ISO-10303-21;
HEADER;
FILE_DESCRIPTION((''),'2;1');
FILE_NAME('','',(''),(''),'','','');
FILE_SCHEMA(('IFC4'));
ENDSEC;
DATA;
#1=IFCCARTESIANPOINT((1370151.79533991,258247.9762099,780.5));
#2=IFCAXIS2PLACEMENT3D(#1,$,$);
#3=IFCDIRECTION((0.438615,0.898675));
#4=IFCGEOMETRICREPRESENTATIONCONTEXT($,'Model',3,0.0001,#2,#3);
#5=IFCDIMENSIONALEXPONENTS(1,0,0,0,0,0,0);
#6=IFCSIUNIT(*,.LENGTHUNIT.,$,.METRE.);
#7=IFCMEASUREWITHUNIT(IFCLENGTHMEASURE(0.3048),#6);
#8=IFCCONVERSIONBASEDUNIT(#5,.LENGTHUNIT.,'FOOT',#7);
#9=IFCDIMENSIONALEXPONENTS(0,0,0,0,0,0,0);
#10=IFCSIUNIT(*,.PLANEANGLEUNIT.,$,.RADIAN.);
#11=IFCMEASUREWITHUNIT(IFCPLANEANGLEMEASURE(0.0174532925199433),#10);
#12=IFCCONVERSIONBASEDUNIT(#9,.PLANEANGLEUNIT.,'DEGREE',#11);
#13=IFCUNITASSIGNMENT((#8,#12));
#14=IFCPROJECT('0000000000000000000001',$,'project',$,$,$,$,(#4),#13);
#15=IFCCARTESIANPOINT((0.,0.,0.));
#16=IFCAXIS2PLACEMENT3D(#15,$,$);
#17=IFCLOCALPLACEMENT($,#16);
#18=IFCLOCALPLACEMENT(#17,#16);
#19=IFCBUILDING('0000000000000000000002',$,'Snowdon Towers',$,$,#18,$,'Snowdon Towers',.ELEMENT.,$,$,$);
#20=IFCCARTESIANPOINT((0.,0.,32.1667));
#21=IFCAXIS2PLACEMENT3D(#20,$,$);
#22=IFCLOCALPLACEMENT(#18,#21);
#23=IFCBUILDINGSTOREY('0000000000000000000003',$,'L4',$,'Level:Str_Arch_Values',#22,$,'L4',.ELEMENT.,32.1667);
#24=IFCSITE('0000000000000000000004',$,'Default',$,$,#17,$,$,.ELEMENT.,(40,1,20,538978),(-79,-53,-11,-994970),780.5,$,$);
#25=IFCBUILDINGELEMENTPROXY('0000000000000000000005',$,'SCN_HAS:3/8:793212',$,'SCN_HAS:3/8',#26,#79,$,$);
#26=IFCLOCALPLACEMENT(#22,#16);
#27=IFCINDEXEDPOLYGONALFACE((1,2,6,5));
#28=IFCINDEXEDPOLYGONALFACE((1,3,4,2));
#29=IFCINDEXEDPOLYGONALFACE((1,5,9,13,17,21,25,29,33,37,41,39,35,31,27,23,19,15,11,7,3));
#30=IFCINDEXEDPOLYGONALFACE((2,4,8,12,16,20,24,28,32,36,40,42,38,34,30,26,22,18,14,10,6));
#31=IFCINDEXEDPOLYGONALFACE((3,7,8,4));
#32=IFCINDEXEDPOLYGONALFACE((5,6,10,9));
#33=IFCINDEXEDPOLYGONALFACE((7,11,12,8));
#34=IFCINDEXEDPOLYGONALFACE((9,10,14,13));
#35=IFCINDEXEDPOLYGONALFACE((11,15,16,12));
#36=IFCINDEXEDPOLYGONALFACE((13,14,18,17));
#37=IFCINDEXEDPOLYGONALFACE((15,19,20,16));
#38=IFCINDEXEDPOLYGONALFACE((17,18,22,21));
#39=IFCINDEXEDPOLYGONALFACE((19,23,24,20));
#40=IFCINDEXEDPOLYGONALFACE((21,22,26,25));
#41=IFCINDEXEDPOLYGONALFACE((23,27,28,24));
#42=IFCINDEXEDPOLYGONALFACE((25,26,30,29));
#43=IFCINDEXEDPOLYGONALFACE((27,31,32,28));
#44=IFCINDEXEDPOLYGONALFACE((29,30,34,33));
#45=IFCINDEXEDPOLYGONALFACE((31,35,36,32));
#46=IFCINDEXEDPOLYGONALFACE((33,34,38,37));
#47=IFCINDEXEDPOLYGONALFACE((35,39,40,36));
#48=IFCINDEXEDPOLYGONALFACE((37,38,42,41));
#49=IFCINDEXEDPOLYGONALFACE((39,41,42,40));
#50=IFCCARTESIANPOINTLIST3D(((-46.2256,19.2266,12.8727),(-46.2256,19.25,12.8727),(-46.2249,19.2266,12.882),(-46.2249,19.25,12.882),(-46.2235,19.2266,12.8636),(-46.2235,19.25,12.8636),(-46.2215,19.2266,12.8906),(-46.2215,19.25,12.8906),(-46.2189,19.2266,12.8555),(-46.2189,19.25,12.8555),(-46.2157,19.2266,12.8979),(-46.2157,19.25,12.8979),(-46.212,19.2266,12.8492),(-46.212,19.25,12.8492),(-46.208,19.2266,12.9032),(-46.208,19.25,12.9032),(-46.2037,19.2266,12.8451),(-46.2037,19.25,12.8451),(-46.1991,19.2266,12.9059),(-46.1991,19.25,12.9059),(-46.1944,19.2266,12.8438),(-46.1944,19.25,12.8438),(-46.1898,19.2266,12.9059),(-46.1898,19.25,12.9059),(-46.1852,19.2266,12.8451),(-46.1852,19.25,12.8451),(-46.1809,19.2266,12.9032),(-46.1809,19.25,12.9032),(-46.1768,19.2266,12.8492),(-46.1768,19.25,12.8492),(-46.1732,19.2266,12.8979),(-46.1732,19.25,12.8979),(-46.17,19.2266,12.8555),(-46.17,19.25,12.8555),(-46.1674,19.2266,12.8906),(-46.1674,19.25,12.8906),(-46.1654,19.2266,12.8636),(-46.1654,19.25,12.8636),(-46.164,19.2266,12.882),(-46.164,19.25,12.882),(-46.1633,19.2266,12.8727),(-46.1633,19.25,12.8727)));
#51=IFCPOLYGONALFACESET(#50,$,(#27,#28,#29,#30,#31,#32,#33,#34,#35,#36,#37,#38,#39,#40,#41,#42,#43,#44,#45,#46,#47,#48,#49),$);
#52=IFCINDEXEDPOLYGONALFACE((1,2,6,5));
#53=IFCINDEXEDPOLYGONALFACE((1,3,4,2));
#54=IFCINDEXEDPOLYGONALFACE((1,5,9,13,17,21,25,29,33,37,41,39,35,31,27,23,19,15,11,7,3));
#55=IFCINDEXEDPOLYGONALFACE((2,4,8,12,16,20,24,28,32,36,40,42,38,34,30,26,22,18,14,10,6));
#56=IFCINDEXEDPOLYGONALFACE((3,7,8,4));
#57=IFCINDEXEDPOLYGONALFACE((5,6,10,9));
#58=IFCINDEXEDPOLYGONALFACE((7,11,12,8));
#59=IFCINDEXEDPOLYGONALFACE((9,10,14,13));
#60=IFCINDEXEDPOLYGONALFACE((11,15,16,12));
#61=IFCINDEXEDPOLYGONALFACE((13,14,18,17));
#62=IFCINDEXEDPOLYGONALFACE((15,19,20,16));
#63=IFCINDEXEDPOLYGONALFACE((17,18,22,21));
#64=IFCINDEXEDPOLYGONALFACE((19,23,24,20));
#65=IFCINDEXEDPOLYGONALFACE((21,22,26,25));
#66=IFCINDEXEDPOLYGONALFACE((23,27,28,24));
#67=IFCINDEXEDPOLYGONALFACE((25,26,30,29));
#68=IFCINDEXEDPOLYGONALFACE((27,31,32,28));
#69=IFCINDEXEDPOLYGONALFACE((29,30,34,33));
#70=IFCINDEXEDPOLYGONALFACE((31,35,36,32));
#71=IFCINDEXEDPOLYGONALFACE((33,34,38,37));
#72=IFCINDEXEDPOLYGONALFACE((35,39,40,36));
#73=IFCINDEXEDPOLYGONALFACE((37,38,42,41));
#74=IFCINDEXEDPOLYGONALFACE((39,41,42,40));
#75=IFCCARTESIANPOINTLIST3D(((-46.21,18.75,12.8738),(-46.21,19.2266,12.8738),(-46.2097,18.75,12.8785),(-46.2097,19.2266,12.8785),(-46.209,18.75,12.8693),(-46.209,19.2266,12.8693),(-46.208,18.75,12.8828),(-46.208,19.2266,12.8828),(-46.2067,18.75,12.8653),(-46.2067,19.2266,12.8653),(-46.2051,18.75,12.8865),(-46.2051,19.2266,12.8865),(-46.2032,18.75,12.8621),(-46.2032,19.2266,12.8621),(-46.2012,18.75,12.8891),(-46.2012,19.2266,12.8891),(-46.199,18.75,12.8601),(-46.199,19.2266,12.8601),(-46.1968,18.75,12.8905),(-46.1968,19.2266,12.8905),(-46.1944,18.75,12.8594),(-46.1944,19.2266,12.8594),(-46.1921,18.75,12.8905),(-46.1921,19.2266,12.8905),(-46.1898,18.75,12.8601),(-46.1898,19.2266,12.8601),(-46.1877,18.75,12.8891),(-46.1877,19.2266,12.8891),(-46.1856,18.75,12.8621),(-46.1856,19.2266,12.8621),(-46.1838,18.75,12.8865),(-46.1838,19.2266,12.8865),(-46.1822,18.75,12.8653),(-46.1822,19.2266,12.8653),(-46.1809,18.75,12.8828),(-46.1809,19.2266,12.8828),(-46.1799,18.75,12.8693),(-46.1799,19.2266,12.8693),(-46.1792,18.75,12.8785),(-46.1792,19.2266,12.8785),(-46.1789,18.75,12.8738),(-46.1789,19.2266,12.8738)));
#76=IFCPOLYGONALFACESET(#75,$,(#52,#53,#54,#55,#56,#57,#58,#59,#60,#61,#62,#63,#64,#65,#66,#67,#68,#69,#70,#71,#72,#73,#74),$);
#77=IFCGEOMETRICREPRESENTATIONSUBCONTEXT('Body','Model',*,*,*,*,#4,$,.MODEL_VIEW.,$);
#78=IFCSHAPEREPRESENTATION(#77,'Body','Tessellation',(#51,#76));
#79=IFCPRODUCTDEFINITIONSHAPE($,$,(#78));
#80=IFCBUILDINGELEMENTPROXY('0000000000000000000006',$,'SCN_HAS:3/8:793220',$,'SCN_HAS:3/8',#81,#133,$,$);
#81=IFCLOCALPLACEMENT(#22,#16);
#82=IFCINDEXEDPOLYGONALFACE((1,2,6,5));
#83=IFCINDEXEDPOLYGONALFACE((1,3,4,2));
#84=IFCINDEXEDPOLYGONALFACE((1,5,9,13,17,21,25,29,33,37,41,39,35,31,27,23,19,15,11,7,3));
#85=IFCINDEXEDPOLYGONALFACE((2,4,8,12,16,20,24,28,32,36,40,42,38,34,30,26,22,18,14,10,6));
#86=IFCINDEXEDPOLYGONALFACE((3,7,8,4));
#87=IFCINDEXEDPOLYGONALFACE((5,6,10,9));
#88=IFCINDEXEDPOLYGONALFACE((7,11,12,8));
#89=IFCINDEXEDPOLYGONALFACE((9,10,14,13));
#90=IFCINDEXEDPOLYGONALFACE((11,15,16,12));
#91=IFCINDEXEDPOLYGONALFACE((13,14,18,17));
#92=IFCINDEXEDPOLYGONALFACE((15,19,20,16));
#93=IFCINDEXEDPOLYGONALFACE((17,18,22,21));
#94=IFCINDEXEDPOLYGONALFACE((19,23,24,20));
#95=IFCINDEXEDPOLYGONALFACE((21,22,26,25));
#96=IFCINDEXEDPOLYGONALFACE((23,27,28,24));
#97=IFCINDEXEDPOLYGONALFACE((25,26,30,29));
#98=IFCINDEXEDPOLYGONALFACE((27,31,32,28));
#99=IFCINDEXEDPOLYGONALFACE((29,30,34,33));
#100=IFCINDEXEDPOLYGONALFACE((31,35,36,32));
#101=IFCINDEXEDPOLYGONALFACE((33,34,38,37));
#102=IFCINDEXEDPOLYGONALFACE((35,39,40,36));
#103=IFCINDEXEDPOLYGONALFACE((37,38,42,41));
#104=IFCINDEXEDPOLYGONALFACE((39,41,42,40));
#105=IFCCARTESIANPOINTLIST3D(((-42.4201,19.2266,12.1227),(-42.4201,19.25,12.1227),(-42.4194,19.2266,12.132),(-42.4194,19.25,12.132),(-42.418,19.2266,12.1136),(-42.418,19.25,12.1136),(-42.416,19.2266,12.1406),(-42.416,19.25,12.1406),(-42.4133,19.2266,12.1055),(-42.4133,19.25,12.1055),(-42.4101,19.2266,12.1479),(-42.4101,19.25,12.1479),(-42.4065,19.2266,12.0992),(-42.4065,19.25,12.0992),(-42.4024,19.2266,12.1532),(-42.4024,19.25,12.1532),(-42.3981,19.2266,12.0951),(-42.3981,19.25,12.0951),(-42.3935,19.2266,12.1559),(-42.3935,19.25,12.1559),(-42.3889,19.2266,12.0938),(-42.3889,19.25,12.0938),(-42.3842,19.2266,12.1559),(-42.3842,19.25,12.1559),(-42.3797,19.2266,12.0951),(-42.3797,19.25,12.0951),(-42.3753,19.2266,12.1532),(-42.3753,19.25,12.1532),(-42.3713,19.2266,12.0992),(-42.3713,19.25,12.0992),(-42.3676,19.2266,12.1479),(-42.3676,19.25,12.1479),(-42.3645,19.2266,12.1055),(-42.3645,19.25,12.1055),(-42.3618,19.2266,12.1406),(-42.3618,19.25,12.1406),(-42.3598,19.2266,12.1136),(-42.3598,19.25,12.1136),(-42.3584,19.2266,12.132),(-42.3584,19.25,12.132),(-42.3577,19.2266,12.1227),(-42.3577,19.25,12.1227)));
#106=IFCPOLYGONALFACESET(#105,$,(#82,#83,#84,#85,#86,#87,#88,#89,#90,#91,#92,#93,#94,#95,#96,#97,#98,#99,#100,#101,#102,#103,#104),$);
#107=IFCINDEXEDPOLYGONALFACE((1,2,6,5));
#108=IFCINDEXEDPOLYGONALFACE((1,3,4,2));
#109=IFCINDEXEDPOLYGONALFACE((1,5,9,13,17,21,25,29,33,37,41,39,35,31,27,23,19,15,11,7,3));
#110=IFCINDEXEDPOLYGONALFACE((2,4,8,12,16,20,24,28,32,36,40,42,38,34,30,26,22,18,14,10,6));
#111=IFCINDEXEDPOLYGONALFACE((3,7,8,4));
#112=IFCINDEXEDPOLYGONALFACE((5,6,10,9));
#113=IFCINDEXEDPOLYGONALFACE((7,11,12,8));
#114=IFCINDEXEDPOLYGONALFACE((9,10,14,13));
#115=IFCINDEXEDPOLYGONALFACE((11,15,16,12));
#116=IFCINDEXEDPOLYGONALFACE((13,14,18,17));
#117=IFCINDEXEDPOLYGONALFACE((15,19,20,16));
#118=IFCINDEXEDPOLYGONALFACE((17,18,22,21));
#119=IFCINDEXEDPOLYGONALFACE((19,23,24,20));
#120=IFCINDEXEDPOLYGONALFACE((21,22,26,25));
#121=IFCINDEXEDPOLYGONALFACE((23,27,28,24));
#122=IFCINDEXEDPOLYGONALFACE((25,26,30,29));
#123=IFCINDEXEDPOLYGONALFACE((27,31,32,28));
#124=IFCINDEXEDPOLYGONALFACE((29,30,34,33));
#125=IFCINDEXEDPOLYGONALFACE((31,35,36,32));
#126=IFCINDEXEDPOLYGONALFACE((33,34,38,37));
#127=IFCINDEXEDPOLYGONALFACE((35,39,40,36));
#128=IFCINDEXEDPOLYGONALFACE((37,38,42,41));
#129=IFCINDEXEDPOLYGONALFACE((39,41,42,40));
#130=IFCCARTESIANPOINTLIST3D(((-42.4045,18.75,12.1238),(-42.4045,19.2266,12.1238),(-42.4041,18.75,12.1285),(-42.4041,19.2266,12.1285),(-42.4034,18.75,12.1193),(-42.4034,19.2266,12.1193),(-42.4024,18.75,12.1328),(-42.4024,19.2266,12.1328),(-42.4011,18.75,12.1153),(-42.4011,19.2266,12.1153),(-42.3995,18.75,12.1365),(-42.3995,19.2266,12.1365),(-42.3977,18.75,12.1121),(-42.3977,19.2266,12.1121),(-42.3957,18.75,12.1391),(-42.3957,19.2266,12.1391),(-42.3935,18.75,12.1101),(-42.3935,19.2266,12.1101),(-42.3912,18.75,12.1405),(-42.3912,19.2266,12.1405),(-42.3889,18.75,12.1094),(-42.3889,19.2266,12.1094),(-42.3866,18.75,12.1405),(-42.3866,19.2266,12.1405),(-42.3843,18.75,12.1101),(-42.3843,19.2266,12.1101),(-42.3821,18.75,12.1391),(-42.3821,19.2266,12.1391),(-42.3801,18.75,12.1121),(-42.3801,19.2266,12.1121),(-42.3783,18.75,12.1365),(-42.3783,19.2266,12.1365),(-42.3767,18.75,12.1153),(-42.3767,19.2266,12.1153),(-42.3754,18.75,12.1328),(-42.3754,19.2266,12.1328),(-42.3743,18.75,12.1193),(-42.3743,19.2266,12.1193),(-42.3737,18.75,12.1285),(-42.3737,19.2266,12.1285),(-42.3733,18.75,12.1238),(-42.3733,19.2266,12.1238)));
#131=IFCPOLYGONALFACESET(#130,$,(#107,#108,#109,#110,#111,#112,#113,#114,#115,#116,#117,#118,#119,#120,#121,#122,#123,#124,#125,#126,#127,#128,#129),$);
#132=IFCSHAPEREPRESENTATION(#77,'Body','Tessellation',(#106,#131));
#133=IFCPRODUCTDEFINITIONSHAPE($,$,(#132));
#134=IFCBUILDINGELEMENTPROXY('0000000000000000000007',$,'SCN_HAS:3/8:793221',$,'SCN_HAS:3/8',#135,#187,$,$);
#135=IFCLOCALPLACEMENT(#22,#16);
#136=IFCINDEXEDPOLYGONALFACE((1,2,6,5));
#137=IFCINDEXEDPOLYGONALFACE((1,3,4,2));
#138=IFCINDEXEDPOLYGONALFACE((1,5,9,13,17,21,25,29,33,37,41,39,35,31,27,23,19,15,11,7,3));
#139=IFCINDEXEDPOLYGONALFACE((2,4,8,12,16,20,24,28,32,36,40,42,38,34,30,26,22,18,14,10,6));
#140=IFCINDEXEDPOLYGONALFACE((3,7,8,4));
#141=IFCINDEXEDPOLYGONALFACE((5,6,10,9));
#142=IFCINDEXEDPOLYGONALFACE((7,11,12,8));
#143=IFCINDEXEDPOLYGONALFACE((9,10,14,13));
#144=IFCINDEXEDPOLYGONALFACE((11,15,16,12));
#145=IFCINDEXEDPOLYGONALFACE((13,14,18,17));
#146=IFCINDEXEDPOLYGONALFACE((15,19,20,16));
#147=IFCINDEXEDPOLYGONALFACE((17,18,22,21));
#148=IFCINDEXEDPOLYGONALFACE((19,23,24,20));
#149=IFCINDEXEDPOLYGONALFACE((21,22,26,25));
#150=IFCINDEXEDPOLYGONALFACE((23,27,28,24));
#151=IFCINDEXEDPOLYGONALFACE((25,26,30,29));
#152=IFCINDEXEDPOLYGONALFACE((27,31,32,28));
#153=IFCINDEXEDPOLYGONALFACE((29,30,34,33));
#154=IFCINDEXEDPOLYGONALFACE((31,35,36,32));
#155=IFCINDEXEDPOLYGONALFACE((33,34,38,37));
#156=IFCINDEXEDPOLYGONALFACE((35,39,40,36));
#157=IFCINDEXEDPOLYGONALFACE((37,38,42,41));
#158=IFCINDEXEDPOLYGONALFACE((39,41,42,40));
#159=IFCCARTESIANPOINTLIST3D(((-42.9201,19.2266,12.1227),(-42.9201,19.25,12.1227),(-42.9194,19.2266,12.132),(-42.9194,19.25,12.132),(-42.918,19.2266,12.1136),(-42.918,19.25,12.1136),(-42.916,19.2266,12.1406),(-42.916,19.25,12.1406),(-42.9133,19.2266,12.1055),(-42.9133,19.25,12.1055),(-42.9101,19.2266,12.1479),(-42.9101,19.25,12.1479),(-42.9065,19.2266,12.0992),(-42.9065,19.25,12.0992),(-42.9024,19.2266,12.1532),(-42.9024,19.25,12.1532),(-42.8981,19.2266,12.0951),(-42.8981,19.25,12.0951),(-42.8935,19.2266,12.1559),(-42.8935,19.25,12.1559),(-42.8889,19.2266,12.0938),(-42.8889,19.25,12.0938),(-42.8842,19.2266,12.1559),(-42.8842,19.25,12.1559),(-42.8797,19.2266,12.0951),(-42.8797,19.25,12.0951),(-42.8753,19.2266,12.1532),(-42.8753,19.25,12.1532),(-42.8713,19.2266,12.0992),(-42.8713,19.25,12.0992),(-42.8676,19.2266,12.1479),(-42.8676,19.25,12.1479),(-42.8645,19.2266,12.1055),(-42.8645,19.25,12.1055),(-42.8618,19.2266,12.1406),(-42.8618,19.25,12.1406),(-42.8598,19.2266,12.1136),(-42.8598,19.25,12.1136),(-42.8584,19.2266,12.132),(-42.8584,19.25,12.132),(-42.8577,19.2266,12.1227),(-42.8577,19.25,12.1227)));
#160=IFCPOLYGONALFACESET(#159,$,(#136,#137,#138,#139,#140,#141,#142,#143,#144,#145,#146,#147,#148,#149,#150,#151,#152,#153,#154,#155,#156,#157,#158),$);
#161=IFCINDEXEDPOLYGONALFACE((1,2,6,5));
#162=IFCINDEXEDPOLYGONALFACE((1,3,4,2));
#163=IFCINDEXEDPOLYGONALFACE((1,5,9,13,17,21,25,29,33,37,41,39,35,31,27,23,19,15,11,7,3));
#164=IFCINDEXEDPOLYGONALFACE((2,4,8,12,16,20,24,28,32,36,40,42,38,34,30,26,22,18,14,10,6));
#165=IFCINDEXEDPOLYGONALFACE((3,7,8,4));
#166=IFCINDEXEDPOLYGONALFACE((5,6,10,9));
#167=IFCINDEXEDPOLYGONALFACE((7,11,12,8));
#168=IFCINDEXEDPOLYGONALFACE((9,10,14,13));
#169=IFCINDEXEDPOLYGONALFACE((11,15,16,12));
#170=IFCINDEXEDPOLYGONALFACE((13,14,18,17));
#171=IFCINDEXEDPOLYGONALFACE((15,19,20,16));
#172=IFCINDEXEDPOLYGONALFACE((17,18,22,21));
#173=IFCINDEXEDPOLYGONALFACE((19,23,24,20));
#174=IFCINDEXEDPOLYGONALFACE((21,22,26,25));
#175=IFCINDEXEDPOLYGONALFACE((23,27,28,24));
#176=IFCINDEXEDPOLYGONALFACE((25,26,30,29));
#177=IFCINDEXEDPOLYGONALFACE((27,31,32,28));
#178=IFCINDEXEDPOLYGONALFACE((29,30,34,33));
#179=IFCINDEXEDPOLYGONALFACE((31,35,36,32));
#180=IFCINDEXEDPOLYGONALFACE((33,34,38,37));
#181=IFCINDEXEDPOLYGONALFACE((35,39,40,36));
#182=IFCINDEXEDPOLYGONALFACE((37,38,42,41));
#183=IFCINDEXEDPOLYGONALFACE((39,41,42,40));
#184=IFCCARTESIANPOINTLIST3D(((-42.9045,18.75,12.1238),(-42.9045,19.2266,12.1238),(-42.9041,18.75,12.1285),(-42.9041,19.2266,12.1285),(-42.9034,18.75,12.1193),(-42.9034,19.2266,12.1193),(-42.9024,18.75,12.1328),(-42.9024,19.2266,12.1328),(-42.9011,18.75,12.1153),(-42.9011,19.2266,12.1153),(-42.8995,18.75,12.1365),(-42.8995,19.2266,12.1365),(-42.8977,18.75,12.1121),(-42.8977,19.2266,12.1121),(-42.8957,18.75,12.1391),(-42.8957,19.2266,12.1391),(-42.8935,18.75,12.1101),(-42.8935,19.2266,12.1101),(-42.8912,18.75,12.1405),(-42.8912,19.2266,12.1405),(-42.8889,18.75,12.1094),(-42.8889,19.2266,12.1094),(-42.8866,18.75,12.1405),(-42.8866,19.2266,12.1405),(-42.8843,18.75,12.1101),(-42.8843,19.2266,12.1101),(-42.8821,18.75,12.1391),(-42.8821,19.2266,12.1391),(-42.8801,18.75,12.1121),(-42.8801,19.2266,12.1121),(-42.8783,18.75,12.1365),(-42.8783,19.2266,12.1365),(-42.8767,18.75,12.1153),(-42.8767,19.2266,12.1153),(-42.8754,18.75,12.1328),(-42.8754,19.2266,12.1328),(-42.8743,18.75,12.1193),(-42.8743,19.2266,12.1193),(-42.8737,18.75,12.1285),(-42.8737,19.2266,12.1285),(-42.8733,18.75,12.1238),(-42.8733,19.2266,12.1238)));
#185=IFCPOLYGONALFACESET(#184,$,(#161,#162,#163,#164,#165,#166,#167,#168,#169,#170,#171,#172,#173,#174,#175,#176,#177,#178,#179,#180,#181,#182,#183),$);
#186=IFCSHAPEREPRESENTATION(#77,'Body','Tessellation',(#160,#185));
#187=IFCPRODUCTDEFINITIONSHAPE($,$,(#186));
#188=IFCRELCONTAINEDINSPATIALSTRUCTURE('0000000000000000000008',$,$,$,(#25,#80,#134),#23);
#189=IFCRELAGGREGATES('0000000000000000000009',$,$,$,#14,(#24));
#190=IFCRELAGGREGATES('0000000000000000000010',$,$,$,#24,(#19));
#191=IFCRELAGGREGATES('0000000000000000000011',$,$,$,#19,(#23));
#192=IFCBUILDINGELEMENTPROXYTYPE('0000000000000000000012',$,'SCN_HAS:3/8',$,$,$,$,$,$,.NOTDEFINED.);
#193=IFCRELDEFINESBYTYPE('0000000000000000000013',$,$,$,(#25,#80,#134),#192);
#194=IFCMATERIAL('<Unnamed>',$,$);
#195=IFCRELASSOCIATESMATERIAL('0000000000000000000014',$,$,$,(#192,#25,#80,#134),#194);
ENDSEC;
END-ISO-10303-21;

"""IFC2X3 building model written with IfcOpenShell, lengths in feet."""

from ifc_helpers import new_model, entity, si_unit, converted_unit, direction, frame, frame_2d, origin, place, context, subcontext, project, spatial, circle, extrude, source, transform, mapped, material, type_object, type_shapes, element, save


model = new_model("IFC2X3")

# Units and contexts
model_context = context("Model", 3, precision=0.0001, world=frame((1370151.79533991, 258247.9762099, 780.5)), true_north=direction((0.438615, 0.898675)))
body_context = subcontext(model_context, "Body", "Model", "MODEL_VIEW")
ifc_project = project(units=[converted_unit("LENGTHUNIT", "FOOT", entity("IfcLengthMeasure", 0.3048), si_unit("LENGTHUNIT", "METRE"), dimensions=[1, 0, 0, 0, 0, 0, 0]), converted_unit("PLANEANGLEUNIT", "DEGREE", entity("IfcPlaneAngleMeasure", 0.0174532925199433), si_unit("PLANEANGLEUNIT", "RADIAN"), dimensions=[0, 0, 0, 0, 0, 0, 0])], contexts=[model_context])

# Site, building, storey
site_placement = place(None, origin())
site = spatial("IfcSite", under=ifc_project, at=site_placement, Name="Default", CompositionType="ELEMENT", RefLatitude=(40, 1, 20, 538978), RefLongitude=(-79, -53, -11, -994970), RefElevation=780.5)
building_placement = place(site_placement, origin())
building = spatial("IfcBuilding", under=site, at=building_placement, Name="Snowdon Towers", LongName="Snowdon Towers", CompositionType="ELEMENT")
storey_placement = place(building_placement, frame((0.0, 0.0, 32.1667)))
storey = spatial("IfcBuildingStorey", under=building, at=storey_placement, Name="L4", ObjectType="Level:Str_Arch_Values", LongName="L4", CompositionType="ELEMENT", Elevation=32.1667)

# Building element proxies
ifc_material_1 = material(Name="<Unnamed>")
building_element_proxy_type = type_object("IfcBuildingElementProxyType", Name="SCN_HAS:3/8", PredefinedType="NOTDEFINED", material=ifc_material_1)
shared_shape = source(origin(), body_context, "Body", "SweptSolid", [
    extrude(circle(Radius=0.0312, at=frame_2d((0.0, 0.0), x_axis=(1.0, 0.0))), frame((0.0, 0.0, -0.5), z_axis=(0.0, 0.0, 1.0), x_axis=(0.0, -1.0, 0.0)), (0.0, 0.0, 1.0), 0.0234),
    extrude(circle(Radius=0.0156, at=frame_2d((0.0, 0.0), x_axis=(1.0, 0.0))), frame((0.0, 0.0, -0.4766), z_axis=(0.0, 0.0, 1.0), x_axis=(0.0, -1.0, 0.0)), (0.0, 0.0, 1.0), 0.4766),
])
type_shapes(building_element_proxy_type, [shared_shape])
for number, where, z_axis, x_axis, name in (
    (1, (-46.1944, 18.75, 12.875), (0.0, -1.0, 0.0), (1.0, 0.0, 0.0), "SCN_HAS:3/8:793212"),
    (2, (-42.3889, 18.75, 12.125), (0.0, -1.0, 0.0), (1.0, 0.0, 0.0), "SCN_HAS:3/8:793220"),
    (3, (-42.8889, 18.75, 12.125), (0.0, -1.0, 0.0), (1.0, 0.0, 0.0), "SCN_HAS:3/8:793221"),
):
    element("IfcBuildingElementProxy", number, at=place(storey_placement, frame(where, z_axis=z_axis, x_axis=x_axis)), inside=storey, type_object=building_element_proxy_type, material=ifc_material_1, Name=name, ObjectType="SCN_HAS:3/8", context=body_context, shape_type="MappedRepresentation", body=[
        mapped(shared_shape, transform((0.0, 0.0, 0.0), scale=1.0)),
    ])

save(model, "model.ifc")
